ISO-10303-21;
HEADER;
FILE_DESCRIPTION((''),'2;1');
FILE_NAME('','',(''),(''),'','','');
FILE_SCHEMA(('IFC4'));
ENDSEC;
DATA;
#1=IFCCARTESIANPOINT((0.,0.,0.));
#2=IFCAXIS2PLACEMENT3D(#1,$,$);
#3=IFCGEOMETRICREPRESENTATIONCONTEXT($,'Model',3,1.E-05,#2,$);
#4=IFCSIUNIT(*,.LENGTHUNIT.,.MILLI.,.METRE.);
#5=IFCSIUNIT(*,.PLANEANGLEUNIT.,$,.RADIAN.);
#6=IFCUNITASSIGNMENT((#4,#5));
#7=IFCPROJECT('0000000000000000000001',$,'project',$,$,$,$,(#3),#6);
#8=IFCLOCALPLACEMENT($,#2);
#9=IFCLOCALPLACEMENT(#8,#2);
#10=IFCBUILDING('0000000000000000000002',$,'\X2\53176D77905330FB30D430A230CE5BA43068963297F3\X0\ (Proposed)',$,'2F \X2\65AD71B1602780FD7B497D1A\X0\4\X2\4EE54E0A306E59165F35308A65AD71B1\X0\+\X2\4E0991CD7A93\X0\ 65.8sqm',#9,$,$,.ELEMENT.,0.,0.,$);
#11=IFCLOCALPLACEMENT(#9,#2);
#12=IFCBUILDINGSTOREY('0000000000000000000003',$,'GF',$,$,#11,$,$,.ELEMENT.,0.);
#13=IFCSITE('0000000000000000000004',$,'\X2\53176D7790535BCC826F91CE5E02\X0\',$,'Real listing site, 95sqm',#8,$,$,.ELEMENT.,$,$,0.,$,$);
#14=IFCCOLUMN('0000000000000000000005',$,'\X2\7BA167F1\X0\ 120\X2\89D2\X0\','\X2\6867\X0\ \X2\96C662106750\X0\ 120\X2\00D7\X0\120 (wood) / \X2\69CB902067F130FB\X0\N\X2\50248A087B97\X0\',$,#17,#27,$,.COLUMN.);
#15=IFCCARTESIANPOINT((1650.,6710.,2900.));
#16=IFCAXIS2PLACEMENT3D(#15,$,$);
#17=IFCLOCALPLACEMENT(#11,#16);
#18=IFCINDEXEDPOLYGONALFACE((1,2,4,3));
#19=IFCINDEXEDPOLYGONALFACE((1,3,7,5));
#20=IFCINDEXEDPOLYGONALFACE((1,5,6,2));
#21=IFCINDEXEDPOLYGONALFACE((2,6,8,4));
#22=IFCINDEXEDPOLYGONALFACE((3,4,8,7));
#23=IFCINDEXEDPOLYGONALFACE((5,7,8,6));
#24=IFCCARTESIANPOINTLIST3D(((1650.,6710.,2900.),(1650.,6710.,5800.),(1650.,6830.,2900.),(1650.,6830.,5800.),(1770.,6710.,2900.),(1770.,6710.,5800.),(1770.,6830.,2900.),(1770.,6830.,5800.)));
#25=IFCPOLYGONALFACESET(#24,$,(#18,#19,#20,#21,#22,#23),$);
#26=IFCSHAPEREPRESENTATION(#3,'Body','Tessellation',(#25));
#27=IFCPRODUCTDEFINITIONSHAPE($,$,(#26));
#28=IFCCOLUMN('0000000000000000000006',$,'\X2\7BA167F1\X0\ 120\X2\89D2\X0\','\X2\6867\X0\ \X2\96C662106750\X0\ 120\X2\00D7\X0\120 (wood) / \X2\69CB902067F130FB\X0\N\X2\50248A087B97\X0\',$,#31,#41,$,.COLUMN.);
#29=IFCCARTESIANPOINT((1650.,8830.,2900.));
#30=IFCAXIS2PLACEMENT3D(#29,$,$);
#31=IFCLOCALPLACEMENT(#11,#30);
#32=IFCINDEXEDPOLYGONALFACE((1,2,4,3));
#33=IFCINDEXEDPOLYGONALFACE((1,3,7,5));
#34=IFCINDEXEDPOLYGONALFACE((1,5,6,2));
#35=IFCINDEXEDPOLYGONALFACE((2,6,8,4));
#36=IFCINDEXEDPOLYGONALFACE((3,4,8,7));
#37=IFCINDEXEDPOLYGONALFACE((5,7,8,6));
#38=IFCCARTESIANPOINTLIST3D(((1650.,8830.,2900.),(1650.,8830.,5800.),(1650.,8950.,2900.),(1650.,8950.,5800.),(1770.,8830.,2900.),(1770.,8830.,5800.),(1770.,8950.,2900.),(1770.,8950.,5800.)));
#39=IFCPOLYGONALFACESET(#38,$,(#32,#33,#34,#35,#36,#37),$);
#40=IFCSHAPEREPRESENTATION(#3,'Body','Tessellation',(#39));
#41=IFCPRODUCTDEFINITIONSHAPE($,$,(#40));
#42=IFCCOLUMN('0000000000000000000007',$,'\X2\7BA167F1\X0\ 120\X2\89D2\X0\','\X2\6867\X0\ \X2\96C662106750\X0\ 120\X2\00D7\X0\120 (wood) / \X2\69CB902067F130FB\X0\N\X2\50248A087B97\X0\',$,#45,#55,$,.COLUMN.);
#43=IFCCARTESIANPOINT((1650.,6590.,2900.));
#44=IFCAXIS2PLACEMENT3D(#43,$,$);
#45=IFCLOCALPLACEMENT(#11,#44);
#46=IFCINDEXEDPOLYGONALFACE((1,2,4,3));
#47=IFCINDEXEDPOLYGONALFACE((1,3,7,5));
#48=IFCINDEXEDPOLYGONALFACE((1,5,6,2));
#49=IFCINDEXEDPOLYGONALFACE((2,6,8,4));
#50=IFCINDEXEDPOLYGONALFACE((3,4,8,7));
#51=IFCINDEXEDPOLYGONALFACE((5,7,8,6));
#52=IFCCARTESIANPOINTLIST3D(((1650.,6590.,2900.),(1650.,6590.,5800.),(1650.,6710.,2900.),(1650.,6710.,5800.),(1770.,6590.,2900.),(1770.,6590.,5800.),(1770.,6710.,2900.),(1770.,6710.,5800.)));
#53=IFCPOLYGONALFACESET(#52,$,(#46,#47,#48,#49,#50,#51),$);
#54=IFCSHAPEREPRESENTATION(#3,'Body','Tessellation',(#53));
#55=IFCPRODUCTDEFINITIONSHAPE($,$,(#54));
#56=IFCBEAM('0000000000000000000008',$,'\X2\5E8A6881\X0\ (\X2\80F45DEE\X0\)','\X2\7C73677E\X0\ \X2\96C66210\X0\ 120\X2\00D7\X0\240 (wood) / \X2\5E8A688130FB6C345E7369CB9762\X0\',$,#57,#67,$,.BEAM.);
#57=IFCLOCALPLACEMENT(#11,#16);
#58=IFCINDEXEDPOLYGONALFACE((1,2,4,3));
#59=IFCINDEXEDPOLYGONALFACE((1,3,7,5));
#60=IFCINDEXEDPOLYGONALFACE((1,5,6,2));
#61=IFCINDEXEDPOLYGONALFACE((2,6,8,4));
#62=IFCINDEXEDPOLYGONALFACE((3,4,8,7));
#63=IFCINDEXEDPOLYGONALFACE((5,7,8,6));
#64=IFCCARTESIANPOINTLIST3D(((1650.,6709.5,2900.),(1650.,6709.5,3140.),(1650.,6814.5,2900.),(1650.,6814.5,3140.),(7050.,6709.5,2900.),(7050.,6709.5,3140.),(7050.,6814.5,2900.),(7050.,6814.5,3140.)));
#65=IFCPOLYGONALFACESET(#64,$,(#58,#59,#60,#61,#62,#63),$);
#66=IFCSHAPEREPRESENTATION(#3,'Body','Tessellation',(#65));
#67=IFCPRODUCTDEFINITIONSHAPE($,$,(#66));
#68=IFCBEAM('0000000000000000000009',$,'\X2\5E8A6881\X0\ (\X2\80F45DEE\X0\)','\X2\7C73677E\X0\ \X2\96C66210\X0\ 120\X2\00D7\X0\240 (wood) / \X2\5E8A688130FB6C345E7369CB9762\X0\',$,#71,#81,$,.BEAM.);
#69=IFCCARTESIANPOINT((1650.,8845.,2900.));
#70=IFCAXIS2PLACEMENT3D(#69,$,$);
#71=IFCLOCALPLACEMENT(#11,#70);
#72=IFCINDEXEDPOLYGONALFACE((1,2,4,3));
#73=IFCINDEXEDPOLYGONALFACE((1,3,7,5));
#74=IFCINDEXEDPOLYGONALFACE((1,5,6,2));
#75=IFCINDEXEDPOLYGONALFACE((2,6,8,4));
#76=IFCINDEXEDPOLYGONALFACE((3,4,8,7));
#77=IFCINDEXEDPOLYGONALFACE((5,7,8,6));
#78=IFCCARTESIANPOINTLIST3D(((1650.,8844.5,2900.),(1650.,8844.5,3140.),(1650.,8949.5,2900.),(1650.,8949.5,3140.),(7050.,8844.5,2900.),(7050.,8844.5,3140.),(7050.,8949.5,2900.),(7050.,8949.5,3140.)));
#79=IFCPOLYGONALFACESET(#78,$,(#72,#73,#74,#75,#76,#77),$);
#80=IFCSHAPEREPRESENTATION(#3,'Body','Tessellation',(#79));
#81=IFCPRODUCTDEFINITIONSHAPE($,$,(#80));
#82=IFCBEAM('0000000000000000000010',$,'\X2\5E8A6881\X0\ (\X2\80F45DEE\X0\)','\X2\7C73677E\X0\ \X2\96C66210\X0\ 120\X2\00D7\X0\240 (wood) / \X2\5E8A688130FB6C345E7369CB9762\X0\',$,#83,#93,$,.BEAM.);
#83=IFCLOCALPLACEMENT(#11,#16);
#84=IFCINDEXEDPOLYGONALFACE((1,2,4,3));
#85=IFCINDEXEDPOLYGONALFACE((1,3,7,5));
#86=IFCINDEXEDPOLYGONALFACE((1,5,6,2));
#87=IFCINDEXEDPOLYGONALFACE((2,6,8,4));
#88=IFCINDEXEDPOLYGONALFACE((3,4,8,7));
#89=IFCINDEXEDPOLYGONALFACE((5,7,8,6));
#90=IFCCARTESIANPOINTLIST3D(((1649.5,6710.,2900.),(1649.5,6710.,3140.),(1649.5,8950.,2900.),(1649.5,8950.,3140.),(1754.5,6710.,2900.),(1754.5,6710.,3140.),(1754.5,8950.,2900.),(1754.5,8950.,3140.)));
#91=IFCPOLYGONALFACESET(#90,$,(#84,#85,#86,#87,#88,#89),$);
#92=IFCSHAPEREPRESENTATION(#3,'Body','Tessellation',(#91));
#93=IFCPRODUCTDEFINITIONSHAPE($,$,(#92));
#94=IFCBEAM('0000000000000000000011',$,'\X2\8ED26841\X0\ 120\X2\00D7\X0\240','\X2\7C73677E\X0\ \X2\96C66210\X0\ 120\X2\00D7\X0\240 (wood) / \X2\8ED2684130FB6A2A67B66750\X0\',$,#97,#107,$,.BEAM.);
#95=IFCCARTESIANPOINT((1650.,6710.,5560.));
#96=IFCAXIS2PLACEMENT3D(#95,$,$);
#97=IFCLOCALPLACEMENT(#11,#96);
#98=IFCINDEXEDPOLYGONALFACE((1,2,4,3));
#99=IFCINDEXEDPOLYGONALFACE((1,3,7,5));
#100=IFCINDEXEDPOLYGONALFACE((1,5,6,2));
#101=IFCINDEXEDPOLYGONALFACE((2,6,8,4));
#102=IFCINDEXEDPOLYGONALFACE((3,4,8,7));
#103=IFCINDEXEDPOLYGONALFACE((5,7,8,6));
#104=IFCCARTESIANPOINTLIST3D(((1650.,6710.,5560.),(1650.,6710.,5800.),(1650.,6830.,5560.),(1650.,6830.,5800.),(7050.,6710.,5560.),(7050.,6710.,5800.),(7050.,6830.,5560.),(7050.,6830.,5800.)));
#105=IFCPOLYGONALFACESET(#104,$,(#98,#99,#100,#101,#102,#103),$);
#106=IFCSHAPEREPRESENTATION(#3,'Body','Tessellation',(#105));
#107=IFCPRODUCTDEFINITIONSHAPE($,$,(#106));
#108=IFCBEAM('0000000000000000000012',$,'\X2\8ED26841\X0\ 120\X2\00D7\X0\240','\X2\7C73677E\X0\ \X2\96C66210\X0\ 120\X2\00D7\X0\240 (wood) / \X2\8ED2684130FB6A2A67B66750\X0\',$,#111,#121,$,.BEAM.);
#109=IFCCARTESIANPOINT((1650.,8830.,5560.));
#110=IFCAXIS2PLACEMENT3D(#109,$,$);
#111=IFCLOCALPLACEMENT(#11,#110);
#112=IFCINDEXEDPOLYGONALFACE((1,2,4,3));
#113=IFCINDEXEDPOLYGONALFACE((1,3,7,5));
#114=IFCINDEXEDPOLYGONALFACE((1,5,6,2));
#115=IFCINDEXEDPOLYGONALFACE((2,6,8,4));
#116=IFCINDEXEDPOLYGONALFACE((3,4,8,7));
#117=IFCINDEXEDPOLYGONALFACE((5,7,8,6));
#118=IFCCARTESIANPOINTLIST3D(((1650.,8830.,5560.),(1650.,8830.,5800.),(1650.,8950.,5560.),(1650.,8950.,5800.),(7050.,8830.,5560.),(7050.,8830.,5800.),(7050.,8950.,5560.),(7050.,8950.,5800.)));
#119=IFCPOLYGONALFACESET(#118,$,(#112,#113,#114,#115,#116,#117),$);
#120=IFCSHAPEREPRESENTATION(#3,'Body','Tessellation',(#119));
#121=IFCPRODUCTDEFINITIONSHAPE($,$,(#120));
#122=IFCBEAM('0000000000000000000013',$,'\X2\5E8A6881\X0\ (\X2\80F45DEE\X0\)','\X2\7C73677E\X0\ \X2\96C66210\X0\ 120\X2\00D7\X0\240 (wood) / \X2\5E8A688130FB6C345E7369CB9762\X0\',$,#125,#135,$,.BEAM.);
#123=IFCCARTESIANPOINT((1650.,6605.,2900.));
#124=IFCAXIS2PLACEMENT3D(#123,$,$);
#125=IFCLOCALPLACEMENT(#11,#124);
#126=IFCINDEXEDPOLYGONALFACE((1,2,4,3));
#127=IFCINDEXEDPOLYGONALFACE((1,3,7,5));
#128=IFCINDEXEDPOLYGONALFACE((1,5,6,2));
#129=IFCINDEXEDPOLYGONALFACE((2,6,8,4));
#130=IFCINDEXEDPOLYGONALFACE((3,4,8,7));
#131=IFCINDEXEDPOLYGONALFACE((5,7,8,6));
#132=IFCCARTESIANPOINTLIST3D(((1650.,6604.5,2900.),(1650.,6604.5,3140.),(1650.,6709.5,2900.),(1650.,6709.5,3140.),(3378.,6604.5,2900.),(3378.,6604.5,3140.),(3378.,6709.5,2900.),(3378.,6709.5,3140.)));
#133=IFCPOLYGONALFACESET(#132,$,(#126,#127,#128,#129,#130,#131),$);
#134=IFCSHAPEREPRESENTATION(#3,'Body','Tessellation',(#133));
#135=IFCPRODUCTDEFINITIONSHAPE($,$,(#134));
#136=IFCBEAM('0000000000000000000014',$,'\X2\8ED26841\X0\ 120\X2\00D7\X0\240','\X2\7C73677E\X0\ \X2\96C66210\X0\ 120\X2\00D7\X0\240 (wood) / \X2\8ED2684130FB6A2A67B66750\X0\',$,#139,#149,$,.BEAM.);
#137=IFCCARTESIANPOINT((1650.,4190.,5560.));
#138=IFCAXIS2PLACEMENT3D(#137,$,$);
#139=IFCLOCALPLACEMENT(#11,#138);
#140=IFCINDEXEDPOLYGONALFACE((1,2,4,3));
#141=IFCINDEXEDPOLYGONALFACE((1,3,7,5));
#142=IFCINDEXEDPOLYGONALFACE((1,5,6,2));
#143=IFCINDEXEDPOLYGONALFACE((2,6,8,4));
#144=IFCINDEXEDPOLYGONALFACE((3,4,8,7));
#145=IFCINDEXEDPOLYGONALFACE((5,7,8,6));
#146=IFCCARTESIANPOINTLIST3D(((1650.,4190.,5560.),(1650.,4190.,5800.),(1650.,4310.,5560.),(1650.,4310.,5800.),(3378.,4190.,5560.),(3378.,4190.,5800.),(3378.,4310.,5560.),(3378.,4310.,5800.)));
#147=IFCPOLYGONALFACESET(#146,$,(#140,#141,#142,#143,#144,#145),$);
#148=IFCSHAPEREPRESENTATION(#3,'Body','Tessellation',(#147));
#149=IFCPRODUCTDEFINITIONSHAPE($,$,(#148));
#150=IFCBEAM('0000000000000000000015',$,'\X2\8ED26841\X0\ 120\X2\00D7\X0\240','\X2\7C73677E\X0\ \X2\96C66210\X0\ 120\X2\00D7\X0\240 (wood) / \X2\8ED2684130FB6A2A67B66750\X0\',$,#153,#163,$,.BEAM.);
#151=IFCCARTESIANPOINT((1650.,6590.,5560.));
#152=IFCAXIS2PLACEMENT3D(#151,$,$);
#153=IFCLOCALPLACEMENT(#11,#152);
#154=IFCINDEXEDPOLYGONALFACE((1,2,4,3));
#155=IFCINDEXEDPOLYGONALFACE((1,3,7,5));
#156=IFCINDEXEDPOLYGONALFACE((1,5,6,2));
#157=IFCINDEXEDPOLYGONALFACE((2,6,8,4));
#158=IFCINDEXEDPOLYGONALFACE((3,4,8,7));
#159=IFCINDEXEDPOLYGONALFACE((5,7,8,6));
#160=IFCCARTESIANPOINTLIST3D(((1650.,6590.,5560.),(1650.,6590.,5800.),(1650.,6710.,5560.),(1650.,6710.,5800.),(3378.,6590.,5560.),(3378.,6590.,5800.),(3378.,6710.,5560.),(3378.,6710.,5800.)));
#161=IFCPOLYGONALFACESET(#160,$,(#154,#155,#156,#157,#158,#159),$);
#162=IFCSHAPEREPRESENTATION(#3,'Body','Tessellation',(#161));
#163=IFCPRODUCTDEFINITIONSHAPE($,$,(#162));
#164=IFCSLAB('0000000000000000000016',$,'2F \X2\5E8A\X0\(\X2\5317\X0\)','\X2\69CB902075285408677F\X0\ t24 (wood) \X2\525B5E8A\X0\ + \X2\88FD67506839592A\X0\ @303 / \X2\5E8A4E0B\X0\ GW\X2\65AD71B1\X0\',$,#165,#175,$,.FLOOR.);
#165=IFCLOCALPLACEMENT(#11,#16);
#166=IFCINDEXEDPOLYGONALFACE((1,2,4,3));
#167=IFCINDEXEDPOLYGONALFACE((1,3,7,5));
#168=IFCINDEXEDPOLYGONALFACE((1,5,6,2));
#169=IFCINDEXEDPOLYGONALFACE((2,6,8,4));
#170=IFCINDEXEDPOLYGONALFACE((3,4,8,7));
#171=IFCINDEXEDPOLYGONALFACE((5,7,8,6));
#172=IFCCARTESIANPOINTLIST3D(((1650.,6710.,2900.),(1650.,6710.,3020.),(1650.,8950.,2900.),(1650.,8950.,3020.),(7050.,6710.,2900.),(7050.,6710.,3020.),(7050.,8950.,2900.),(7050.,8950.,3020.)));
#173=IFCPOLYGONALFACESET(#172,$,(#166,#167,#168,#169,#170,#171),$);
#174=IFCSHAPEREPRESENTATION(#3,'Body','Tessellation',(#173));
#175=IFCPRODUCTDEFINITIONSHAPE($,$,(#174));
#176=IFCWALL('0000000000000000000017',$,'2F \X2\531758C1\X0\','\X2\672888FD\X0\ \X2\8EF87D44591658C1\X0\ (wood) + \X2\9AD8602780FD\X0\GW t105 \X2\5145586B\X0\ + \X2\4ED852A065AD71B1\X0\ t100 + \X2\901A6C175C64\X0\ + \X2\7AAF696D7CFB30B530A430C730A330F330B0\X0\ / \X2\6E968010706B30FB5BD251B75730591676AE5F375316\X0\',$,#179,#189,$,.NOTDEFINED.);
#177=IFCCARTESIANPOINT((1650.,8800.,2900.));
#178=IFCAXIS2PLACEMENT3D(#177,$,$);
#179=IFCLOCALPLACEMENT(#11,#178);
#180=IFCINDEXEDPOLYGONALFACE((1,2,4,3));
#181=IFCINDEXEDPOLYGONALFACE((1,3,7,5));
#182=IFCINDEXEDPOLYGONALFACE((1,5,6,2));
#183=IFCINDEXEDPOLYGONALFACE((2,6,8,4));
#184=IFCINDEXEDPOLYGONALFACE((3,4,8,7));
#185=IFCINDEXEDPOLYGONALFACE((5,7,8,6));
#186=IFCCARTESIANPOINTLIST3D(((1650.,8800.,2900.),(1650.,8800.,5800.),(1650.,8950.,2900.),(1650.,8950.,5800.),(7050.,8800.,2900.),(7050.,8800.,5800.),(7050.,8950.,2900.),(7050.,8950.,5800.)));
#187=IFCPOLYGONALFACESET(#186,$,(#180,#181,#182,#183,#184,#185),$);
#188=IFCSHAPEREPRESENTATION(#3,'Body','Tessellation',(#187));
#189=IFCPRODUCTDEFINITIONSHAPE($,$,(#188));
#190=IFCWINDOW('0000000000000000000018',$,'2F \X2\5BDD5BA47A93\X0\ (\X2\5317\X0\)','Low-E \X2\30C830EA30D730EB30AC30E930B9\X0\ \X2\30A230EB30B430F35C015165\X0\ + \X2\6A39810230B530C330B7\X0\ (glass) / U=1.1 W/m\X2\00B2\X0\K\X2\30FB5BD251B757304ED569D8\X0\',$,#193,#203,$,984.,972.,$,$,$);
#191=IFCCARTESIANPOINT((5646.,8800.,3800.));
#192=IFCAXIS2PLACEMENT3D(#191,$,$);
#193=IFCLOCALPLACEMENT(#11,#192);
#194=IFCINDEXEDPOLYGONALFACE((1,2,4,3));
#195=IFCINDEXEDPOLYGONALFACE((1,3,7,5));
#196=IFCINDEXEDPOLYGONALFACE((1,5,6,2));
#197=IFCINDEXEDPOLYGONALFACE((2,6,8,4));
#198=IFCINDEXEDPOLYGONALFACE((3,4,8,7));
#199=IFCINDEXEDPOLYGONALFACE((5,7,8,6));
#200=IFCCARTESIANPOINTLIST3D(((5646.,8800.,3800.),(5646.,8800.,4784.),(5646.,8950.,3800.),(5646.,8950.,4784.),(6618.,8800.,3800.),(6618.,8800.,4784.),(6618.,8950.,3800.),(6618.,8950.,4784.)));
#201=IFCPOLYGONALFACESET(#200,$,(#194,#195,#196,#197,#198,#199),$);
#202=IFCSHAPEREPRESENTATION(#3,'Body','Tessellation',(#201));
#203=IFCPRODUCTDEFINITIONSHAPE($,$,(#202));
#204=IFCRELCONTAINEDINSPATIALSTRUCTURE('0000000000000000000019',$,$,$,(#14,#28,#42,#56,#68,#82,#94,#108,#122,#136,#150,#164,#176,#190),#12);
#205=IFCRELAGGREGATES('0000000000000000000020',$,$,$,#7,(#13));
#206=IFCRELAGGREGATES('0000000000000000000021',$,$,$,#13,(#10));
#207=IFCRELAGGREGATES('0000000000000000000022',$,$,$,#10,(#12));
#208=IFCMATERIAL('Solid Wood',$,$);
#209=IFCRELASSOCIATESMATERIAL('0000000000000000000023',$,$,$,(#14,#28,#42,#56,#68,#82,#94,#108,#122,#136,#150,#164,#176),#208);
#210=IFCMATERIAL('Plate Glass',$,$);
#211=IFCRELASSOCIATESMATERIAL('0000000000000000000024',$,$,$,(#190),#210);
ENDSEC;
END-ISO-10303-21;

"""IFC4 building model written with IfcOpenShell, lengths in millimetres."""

from ifc_helpers import new_model, si_unit, frame, frame_2d, origin, place, context, project, spatial, rectangle, extrude, material, element, fill, save


model = new_model("IFC4")

# Units and contexts
model_context = context("Model", 3, precision=1e-05, world=origin())
ifc_project = project(units=[si_unit("LENGTHUNIT", "METRE", prefix="MILLI"), si_unit("PLANEANGLEUNIT", "RADIAN")], contexts=[model_context])

# Site, building, storey
site_placement = place(None, origin())
site = spatial("IfcSite", under=ifc_project, at=site_placement, Name="北海道富良野市", ObjectType="Real listing site, 95sqm", CompositionType="ELEMENT", RefElevation=0.0)
building_placement = place(site_placement, origin())
building = spatial("IfcBuilding", under=site, at=building_placement, Name="北海道・ピアノ室と防音 (Proposed)", ObjectType="2F 断熱性能等級4以上の外張り断熱+三重窓 65.8sqm", CompositionType="ELEMENT", ElevationOfRefHeight=0.0, ElevationOfTerrain=0.0)
storey_placement = place(building_placement, origin())
storey = spatial("IfcBuildingStorey", under=building, at=storey_placement, Name="GF", CompositionType="ELEMENT", Elevation=0.0)

# Columns
ifc_material_1 = material(Name="Solid Wood")
column_1_placement = place(storey_placement, frame((1650.0, 6710.0, 2900.0)))
element("IfcColumn", 1, at=column_1_placement, inside=storey, material=ifc_material_1, Name="管柱 120角", Description="桧 集成材 120×120 (wood) / 構造柱・N値計算", PredefinedType="COLUMN", context=model_context, shape_type="SweptSolid", body=[
    extrude(rectangle(XDim=120.0, YDim=120.0, at=frame_2d((60.0, 60.0))), frame((1650.0, 6710.0, 2900.0)), (0.0, 0.0, 1.0), 2900.0),
])
column_2_placement = place(storey_placement, frame((1650.0, 8830.0, 2900.0)))
element("IfcColumn", 2, at=column_2_placement, inside=storey, material=ifc_material_1, Name="管柱 120角", Description="桧 集成材 120×120 (wood) / 構造柱・N値計算", PredefinedType="COLUMN", context=model_context, shape_type="SweptSolid", body=[
    extrude(rectangle(XDim=120.0, YDim=120.0, at=frame_2d((60.0, 60.0))), frame((1650.0, 8830.0, 2900.0)), (0.0, 0.0, 1.0), 2900.0),
])
column_3_placement = place(storey_placement, frame((1650.0, 6590.0, 2900.0)))
element("IfcColumn", 3, at=column_3_placement, inside=storey, material=ifc_material_1, Name="管柱 120角", Description="桧 集成材 120×120 (wood) / 構造柱・N値計算", PredefinedType="COLUMN", context=model_context, shape_type="SweptSolid", body=[
    extrude(rectangle(XDim=120.0, YDim=120.0, at=frame_2d((60.0, 60.0))), frame((1650.0, 6590.0, 2900.0)), (0.0, 0.0, 1.0), 2900.0),
])

# Beams
beam_1_placement = place(storey_placement, frame((1650.0, 6710.0, 2900.0)))
element("IfcBeam", 4, at=beam_1_placement, inside=storey, material=ifc_material_1, Name="床梁 (胴差)", Description="米松 集成 120×240 (wood) / 床梁・水平構面", PredefinedType="BEAM", context=model_context, shape_type="SweptSolid", body=[
    extrude(rectangle(XDim=5400.0, YDim=105.0, at=frame_2d((2700.0, 52.0))), frame((1650.0, 6710.0, 2900.0)), (0.0, 0.0, 1.0), 240.0),
])
beam_2_placement = place(storey_placement, frame((1650.0, 8845.0, 2900.0)))
element("IfcBeam", 5, at=beam_2_placement, inside=storey, material=ifc_material_1, Name="床梁 (胴差)", Description="米松 集成 120×240 (wood) / 床梁・水平構面", PredefinedType="BEAM", context=model_context, shape_type="SweptSolid", body=[
    extrude(rectangle(XDim=5400.0, YDim=105.0, at=frame_2d((2700.0, 52.0))), frame((1650.0, 8845.0, 2900.0)), (0.0, 0.0, 1.0), 240.0),
])
beam_3_placement = place(storey_placement, frame((1650.0, 6710.0, 2900.0)))
element("IfcBeam", 6, at=beam_3_placement, inside=storey, material=ifc_material_1, Name="床梁 (胴差)", Description="米松 集成 120×240 (wood) / 床梁・水平構面", PredefinedType="BEAM", context=model_context, shape_type="SweptSolid", body=[
    extrude(rectangle(XDim=105.0, YDim=2240.0, at=frame_2d((52.0, 1120.0))), frame((1650.0, 6710.0, 2900.0)), (0.0, 0.0, 1.0), 240.0),
])
beam_4_placement = place(storey_placement, frame((1650.0, 6710.0, 5560.0)))
element("IfcBeam", 7, at=beam_4_placement, inside=storey, material=ifc_material_1, Name="軒桁 120×240", Description="米松 集成 120×240 (wood) / 軒桁・横架材", PredefinedType="BEAM", context=model_context, shape_type="SweptSolid", body=[
    extrude(rectangle(XDim=5400.0, YDim=120.0, at=frame_2d((2700.0, 60.0))), frame((1650.0, 6710.0, 5560.0)), (0.0, 0.0, 1.0), 240.0),
])
beam_5_placement = place(storey_placement, frame((1650.0, 8830.0, 5560.0)))
element("IfcBeam", 8, at=beam_5_placement, inside=storey, material=ifc_material_1, Name="軒桁 120×240", Description="米松 集成 120×240 (wood) / 軒桁・横架材", PredefinedType="BEAM", context=model_context, shape_type="SweptSolid", body=[
    extrude(rectangle(XDim=5400.0, YDim=120.0, at=frame_2d((2700.0, 60.0))), frame((1650.0, 8830.0, 5560.0)), (0.0, 0.0, 1.0), 240.0),
])
beam_6_placement = place(storey_placement, frame((1650.0, 6605.0, 2900.0)))
element("IfcBeam", 9, at=beam_6_placement, inside=storey, material=ifc_material_1, Name="床梁 (胴差)", Description="米松 集成 120×240 (wood) / 床梁・水平構面", PredefinedType="BEAM", context=model_context, shape_type="SweptSolid", body=[
    extrude(rectangle(XDim=1728.0, YDim=105.0, at=frame_2d((864.0, 52.0))), frame((1650.0, 6605.0, 2900.0)), (0.0, 0.0, 1.0), 240.0),
])
beam_7_placement = place(storey_placement, frame((1650.0, 4190.0, 5560.0)))
element("IfcBeam", 10, at=beam_7_placement, inside=storey, material=ifc_material_1, Name="軒桁 120×240", Description="米松 集成 120×240 (wood) / 軒桁・横架材", PredefinedType="BEAM", context=model_context, shape_type="SweptSolid", body=[
    extrude(rectangle(XDim=1728.0, YDim=120.0, at=frame_2d((864.0, 60.0))), frame((1650.0, 4190.0, 5560.0)), (0.0, 0.0, 1.0), 240.0),
])
beam_8_placement = place(storey_placement, frame((1650.0, 6590.0, 5560.0)))
element("IfcBeam", 11, at=beam_8_placement, inside=storey, material=ifc_material_1, Name="軒桁 120×240", Description="米松 集成 120×240 (wood) / 軒桁・横架材", PredefinedType="BEAM", context=model_context, shape_type="SweptSolid", body=[
    extrude(rectangle(XDim=1728.0, YDim=120.0, at=frame_2d((864.0, 60.0))), frame((1650.0, 6590.0, 5560.0)), (0.0, 0.0, 1.0), 240.0),
])

# Slab
slab_placement = place(storey_placement, frame((1650.0, 6710.0, 2900.0)))
element("IfcSlab", 12, at=slab_placement, inside=storey, material=ifc_material_1, Name="2F 床(北)", Description="構造用合板 t24 (wood) 剛床 + 製材根太 @303 / 床下 GW断熱", PredefinedType="FLOOR", context=model_context, shape_type="SweptSolid", body=[
    extrude(rectangle(XDim=5400.0, YDim=2240.0, at=frame_2d((2700.0, 1120.0))), frame((1650.0, 6710.0, 2900.0)), (0.0, 0.0, 1.0), 120.0),
])

# Wall, opening, window
wall_placement = place(storey_placement, frame((1650.0, 8800.0, 2900.0)))
wall = element("IfcWall", 13, at=wall_placement, inside=storey, material=ifc_material_1, Name="2F 北壁", Description="木製 軸組外壁 (wood) + 高性能GW t105 充填 + 付加断熱 t100 + 通気層 + 窯業系サイディング / 準耐火・寒冷地外皮強化", PredefinedType="NOTDEFINED", context=model_context, shape_type="SweptSolid", body=[
    extrude(rectangle(XDim=5400.0, YDim=150.0, at=frame_2d((2700.0, 75.0))), frame((1650.0, 8800.0, 2900.0)), (0.0, 0.0, 1.0), 2900.0),
])
opening_placement = place(storey_placement, frame((5646.0, 8800.0, 3800.0)))
opening = element("IfcOpeningElement", 14, at=opening_placement, cuts=wall, PredefinedType="NOTDEFINED", context=model_context, shape_type="SweptSolid", body=[
    extrude(rectangle(XDim=972.0, YDim=150.0, at=frame_2d((486.0, 75.0))), frame((5646.0, 8800.0, 3800.0)), (0.0, 0.0, 1.0), 984.0),
])
ifc_material_2 = material(Name="Plate Glass")
window_placement = place(storey_placement, frame((5646.0, 8800.0, 3800.0)))
window = element("IfcWindow", 15, at=window_placement, inside=storey, material=ifc_material_2, Name="2F 寝室窓 (北)", Description="Low-E トリプルガラス アルゴン封入 + 樹脂サッシ (glass) / U=1.1 W/m²K・寒冷地仕様", OverallHeight=984.0, OverallWidth=972.0, context=model_context, shape_type="SweptSolid", body=[
    extrude(rectangle(XDim=972.0, YDim=150.0, at=frame_2d((486.0, 75.0))), frame((5646.0, 8800.0, 3800.0)), (0.0, 0.0, 1.0), 984.0),
])
fill(opening, window)

save(model, "model.ifc")
